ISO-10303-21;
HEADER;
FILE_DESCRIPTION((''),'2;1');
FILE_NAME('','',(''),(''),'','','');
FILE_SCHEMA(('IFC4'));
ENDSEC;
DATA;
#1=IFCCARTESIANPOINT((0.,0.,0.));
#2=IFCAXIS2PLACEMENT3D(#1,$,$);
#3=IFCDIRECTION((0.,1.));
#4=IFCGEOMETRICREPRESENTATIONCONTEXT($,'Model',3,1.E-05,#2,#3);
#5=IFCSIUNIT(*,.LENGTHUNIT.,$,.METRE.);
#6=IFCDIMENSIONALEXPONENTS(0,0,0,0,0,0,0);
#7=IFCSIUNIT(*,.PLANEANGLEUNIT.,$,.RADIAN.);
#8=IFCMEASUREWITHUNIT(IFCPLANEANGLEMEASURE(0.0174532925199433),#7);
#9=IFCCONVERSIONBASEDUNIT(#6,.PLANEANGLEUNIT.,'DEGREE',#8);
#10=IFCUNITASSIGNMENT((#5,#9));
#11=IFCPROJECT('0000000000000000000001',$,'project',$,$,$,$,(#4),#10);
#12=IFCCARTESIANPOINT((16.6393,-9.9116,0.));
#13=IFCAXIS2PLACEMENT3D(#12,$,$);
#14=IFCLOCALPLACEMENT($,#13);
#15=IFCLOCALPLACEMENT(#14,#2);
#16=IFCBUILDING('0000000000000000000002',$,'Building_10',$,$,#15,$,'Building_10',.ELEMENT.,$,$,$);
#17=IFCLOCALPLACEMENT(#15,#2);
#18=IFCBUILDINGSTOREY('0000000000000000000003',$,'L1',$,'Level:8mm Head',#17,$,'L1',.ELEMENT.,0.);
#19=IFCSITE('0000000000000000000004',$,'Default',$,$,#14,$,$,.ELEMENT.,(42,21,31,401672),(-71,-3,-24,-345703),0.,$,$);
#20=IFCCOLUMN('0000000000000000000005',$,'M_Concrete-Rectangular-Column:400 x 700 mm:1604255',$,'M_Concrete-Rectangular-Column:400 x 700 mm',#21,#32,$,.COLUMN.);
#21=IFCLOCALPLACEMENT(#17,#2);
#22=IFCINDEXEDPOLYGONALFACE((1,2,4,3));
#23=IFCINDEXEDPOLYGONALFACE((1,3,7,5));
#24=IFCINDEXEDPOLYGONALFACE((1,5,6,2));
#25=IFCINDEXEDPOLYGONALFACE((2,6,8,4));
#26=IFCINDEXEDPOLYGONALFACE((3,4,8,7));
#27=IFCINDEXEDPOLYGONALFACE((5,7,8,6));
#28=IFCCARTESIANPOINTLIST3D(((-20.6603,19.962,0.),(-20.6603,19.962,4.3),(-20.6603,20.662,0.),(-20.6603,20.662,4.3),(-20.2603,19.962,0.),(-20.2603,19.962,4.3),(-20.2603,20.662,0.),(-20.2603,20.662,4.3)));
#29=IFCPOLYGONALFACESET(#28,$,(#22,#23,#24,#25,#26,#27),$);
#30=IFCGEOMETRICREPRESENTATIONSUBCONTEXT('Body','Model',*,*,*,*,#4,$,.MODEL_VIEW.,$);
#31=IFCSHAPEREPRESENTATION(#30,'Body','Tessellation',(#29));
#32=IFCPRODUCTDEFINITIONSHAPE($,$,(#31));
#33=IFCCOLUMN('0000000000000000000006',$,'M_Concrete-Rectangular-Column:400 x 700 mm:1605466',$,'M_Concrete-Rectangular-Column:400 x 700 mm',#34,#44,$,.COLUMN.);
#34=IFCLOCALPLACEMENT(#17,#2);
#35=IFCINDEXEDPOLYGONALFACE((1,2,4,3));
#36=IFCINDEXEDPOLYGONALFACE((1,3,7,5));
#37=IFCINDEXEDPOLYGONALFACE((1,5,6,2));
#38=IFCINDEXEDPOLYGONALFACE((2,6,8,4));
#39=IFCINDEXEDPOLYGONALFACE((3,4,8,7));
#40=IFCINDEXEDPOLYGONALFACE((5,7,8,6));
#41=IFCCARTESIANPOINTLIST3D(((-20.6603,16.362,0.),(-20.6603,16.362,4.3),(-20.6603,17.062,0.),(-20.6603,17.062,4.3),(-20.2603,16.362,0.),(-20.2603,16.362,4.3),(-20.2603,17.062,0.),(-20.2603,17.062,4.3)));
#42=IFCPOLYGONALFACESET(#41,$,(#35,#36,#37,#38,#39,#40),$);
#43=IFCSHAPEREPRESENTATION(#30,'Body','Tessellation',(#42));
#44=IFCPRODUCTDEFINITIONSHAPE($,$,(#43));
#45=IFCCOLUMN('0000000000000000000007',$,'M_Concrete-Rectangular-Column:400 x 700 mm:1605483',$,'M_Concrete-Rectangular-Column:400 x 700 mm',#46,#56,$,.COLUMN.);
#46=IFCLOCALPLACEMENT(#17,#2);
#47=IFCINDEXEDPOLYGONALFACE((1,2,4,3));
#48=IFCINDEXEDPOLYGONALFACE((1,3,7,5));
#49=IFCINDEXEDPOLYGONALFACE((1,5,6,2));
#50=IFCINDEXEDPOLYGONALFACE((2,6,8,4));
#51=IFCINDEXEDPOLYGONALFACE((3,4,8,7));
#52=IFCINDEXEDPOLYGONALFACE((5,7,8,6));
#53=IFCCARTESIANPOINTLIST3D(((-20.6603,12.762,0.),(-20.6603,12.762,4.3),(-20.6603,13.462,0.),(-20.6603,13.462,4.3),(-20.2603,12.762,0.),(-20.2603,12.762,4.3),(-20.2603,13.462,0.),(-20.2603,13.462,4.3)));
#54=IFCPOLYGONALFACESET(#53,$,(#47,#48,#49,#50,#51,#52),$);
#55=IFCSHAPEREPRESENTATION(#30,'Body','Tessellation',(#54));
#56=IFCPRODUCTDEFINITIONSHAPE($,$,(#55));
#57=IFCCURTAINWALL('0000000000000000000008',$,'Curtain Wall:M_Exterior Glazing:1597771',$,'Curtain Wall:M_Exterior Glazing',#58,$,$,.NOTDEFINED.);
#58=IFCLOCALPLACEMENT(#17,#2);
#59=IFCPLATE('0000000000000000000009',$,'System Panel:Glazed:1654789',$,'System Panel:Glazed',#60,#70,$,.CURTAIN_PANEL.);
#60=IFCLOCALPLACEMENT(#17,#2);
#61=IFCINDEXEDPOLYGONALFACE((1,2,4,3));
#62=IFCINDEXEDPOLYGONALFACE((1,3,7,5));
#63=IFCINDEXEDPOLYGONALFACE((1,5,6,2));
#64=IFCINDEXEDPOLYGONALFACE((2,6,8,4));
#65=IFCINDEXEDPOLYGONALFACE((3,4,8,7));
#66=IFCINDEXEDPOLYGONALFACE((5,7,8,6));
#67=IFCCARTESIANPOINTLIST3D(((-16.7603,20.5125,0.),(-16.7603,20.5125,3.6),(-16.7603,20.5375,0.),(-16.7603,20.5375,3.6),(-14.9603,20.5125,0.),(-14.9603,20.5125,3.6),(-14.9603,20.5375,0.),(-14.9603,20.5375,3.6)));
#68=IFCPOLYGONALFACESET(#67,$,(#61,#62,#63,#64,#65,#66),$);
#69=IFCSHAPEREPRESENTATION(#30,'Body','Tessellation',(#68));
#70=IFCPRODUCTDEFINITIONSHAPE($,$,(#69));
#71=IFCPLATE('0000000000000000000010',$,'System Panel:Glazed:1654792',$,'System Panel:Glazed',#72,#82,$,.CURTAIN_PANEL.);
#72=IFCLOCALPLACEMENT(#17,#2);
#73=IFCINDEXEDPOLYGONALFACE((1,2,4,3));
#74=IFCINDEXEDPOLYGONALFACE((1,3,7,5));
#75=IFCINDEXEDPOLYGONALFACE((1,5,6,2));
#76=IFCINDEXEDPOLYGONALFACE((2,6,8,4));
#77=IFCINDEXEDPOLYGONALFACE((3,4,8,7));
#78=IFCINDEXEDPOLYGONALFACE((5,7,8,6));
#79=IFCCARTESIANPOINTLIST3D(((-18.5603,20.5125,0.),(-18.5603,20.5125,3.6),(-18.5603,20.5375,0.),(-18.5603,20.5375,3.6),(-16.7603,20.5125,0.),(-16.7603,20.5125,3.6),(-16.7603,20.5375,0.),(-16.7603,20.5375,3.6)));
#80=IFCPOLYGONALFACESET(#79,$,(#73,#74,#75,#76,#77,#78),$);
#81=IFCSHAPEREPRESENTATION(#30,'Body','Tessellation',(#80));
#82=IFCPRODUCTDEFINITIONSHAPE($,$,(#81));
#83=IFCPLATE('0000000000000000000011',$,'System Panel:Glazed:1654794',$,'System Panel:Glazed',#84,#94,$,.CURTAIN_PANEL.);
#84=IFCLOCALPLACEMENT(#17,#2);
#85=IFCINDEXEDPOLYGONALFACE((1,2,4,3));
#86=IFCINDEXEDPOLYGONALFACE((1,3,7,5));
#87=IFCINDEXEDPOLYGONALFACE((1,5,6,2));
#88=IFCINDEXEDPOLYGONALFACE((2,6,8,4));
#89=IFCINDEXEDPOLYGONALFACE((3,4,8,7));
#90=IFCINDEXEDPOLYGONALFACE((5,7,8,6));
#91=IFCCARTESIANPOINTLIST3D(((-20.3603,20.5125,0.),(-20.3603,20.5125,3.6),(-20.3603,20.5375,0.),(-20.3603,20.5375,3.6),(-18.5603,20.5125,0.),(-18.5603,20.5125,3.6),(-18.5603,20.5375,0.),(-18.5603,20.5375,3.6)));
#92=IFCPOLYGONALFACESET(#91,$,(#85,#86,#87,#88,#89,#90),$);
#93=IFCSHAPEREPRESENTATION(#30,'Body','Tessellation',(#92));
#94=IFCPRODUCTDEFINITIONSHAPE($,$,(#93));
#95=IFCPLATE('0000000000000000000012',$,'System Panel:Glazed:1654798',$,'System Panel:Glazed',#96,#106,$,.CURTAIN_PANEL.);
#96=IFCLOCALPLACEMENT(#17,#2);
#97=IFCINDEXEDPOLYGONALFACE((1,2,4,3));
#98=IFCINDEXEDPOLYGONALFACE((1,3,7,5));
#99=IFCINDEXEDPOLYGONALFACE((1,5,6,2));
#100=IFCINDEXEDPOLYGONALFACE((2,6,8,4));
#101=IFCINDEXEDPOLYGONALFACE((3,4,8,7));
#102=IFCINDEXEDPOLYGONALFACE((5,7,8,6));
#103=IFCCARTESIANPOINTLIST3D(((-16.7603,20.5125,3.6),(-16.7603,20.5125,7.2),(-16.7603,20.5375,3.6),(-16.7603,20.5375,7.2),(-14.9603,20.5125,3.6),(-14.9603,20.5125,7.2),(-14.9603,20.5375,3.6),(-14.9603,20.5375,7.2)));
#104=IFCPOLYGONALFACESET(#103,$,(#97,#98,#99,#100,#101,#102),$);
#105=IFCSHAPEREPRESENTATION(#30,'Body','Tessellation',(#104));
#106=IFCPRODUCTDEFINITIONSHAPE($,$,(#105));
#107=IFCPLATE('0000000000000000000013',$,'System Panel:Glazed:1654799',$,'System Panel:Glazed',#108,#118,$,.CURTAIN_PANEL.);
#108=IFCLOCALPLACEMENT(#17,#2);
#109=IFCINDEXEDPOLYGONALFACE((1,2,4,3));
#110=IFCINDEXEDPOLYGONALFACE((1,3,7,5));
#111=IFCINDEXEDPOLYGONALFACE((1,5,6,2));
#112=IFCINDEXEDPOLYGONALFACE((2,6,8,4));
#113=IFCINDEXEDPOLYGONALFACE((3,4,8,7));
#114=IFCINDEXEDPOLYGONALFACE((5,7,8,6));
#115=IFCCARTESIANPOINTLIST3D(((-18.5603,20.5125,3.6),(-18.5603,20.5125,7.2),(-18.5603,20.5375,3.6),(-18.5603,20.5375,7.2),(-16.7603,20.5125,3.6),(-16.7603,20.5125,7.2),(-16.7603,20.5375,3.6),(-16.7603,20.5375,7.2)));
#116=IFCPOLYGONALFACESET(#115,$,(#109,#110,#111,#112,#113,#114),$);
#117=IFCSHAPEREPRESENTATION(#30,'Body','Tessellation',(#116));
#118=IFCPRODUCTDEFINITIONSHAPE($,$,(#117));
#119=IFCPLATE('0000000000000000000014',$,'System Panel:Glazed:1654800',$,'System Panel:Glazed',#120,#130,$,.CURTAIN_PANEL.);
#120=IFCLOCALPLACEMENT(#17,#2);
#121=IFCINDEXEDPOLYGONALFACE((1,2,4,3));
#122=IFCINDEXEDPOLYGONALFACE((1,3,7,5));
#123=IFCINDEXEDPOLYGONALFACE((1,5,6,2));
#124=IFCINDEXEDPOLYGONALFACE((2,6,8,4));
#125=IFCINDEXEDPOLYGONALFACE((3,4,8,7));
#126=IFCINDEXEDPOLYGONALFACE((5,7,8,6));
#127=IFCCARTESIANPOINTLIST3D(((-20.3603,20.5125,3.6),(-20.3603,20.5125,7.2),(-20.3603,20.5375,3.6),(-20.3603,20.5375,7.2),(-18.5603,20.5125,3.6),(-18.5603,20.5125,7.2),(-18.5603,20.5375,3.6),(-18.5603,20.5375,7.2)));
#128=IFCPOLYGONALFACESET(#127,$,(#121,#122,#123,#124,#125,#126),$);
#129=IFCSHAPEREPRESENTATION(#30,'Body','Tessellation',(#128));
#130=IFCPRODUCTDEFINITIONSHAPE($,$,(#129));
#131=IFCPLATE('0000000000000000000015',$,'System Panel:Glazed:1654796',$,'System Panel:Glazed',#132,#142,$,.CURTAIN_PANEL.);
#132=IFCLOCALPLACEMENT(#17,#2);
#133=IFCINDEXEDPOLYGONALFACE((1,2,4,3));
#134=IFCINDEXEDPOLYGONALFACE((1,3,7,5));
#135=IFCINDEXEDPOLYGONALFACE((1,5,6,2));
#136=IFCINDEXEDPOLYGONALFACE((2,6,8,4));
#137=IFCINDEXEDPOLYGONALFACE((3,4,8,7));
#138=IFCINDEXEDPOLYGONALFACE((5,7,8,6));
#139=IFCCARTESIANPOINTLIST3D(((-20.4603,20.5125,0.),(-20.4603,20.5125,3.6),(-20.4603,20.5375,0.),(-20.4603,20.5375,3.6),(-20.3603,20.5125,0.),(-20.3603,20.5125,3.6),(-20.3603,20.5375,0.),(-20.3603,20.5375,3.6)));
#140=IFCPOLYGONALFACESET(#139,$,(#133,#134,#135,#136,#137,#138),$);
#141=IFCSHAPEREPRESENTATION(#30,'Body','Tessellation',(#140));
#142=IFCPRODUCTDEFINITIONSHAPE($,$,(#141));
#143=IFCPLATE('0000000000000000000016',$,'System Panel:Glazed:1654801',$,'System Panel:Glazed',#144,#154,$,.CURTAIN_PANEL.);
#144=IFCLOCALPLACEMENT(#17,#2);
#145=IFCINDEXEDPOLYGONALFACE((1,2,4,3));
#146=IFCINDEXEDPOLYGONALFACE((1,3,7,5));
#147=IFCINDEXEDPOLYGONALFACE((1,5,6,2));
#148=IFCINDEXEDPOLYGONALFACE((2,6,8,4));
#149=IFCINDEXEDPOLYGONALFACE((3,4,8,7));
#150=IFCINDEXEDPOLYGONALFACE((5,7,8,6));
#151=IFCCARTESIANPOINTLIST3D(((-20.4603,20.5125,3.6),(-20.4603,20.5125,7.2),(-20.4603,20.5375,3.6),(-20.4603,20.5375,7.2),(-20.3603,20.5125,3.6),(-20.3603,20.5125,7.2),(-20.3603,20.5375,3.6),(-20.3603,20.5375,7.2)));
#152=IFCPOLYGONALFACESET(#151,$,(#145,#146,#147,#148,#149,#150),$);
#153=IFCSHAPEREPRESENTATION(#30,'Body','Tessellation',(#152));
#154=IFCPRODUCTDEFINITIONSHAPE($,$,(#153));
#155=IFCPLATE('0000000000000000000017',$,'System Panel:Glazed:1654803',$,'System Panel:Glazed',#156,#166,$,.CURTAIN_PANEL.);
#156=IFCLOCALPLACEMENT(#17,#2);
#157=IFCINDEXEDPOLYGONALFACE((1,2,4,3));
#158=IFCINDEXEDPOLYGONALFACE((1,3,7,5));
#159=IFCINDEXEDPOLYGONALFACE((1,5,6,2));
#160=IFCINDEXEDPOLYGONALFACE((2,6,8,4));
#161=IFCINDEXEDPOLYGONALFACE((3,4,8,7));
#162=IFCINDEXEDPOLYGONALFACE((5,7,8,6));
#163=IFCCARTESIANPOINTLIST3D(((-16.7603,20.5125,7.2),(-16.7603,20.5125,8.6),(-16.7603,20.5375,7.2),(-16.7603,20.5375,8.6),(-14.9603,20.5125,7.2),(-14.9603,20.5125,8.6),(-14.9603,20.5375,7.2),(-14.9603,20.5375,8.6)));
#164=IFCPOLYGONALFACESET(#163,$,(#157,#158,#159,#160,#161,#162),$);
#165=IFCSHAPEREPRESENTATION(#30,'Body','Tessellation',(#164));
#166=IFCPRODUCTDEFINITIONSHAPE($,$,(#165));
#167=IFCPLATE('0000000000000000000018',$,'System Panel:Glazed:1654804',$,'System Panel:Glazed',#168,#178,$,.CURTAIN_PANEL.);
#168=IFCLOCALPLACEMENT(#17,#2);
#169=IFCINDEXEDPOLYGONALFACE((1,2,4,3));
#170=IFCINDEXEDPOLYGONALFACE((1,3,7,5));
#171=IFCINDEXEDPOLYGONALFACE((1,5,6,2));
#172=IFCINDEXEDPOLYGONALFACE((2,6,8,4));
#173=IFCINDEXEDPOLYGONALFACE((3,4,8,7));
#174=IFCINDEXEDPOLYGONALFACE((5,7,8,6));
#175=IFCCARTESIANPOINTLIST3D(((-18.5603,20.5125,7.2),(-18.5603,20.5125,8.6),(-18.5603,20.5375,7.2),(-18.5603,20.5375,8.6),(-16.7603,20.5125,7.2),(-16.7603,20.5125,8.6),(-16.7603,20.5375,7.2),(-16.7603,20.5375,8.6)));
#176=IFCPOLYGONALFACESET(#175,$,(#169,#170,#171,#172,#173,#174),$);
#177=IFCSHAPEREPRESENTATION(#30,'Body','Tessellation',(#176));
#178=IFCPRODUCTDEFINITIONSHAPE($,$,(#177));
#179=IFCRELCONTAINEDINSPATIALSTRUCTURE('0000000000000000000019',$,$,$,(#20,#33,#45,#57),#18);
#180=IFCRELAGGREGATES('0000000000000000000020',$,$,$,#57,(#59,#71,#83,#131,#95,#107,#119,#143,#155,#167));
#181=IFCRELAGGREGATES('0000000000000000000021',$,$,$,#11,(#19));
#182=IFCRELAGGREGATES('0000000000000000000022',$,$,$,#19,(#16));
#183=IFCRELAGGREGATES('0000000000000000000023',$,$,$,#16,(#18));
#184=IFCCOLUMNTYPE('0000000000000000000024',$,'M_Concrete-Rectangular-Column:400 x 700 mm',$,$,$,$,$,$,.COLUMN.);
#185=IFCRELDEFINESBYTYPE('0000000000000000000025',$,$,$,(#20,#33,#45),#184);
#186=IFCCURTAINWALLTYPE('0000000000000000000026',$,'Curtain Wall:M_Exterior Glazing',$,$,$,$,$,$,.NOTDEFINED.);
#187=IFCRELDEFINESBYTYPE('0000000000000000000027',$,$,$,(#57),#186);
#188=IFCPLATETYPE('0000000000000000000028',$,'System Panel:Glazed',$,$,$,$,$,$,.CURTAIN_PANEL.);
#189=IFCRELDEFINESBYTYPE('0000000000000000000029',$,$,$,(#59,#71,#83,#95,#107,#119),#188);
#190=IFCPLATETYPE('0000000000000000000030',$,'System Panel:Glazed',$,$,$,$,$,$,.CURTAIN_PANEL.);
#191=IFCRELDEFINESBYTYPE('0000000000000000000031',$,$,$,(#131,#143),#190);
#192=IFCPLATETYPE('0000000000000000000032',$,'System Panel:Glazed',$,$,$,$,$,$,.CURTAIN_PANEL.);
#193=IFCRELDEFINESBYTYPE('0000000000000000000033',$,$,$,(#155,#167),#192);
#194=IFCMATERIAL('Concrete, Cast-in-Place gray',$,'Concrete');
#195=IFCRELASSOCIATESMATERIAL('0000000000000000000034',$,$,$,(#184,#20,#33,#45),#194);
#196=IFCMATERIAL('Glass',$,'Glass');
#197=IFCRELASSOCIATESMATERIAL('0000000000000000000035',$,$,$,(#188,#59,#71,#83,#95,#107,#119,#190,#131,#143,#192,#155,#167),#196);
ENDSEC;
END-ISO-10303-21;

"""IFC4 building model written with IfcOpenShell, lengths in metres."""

from ifc_helpers import new_model, entity, si_unit, converted_unit, direction, frame, origin, place, context, subcontext, project, spatial, indexed_curve, outline, extrude, source, transform, mapped, material, type_object, type_shapes, element, aggregate, save


model = new_model("IFC4")

# Units and contexts
model_context = context("Model", 3, precision=1e-05, world=origin(), true_north=direction((0.0, 1.0)))
body_context = subcontext(model_context, "Body", "Model", "MODEL_VIEW")
ifc_project = project(units=[si_unit("LENGTHUNIT", "METRE"), converted_unit("PLANEANGLEUNIT", "DEGREE", entity("IfcPlaneAngleMeasure", 0.0174532925199433), si_unit("PLANEANGLEUNIT", "RADIAN"), dimensions=[0, 0, 0, 0, 0, 0, 0])], contexts=[model_context])

# Site, building, storey
site_placement = place(None, frame((16.6393, -9.9116, 0.0)))
site = spatial("IfcSite", under=ifc_project, at=site_placement, Name="Default", CompositionType="ELEMENT", RefLatitude=(42, 21, 31, 401672), RefLongitude=(-71, -3, -24, -345703), RefElevation=0.0)
building_placement = place(site_placement, origin())
building = spatial("IfcBuilding", under=site, at=building_placement, Name="Building_10", LongName="Building_10", CompositionType="ELEMENT")
storey_placement = place(building_placement, origin())
storey = spatial("IfcBuildingStorey", under=building, at=storey_placement, Name="L1", ObjectType="Level:8mm Head", LongName="L1", CompositionType="ELEMENT", Elevation=0.0)

# Columns
ifc_material_1 = material(Name="Concrete, Cast-in-Place gray", Category="Concrete")
column_type = type_object("IfcColumnType", Name="M_Concrete-Rectangular-Column:400 x 700 mm", PredefinedType="COLUMN", material=ifc_material_1)
shared_shape_1 = source(origin(), body_context, "Body", "SweptSolid", [
    extrude(outline(indexed_curve([(-0.2, -0.35), (0.2, -0.35), (0.2, 0.35), (-0.2, 0.35), (-0.2, -0.35)], self_intersect=False)), frame((0.0, 0.0, 0.0), z_axis=(0.0, 0.0, 1.0), x_axis=(-1.0, 0.0, 0.0)), (0.0, 0.0, 1.0), 4.3),
])
type_shapes(column_type, [shared_shape_1])
for number, where, name in (
    (1, (-20.4603, 20.312, 0.0), "M_Concrete-Rectangular-Column:400 x 700 mm:1604255"),
    (2, (-20.4603, 16.712, 0.0), "M_Concrete-Rectangular-Column:400 x 700 mm:1605466"),
    (3, (-20.4603, 13.112, 0.0), "M_Concrete-Rectangular-Column:400 x 700 mm:1605483"),
):
    element("IfcColumn", number, at=place(storey_placement, frame(where)), inside=storey, type_object=column_type, material=ifc_material_1, Name=name, ObjectType="M_Concrete-Rectangular-Column:400 x 700 mm", PredefinedType="COLUMN", context=body_context, shape_type="MappedRepresentation", body=[
        mapped(shared_shape_1, transform((0.0, 0.0, 0.0), scale=1.0)),
    ])

# Curtain wall, plates
curtain_wall_type = type_object("IfcCurtainWallType", Name="Curtain Wall:M_Exterior Glazing", PredefinedType="NOTDEFINED")
curtain_wall_placement = place(storey_placement, origin())
curtain_wall = element("IfcCurtainWall", 4, at=curtain_wall_placement, inside=storey, type_object=curtain_wall_type, Name="Curtain Wall:M_Exterior Glazing:1597771", ObjectType="Curtain Wall:M_Exterior Glazing", PredefinedType="NOTDEFINED")
ifc_material_2 = material(Name="Glass", Category="Glass")
plate_type_1 = type_object("IfcPlateType", Name="System Panel:Glazed", PredefinedType="CURTAIN_PANEL", material=ifc_material_2)
shared_shape_2 = source(origin(), body_context, "Body", "SweptSolid", [
    extrude(outline(indexed_curve([(-0.0125, -0.9), (0.0125, -0.9), (0.0125, 0.9), (-0.0125, 0.9), (-0.0125, -0.9)], self_intersect=False)), frame((0.0, 0.037, 0.0), z_axis=(0.0, 0.0, 1.0), x_axis=(0.0, 1.0, 0.0)), (0.0, 0.0, 1.0), 3.6),
])
type_shapes(plate_type_1, [shared_shape_2])
plate_1_placement = place(curtain_wall_placement, frame((-15.8603, 20.562, 0.0), z_axis=(0.0, 0.0, 1.0), x_axis=(-1.0, 0.0, 0.0)))
plate_1 = element("IfcPlate", 5, at=plate_1_placement, type_object=plate_type_1, material=ifc_material_2, Name="System Panel:Glazed:1654789", ObjectType="System Panel:Glazed", PredefinedType="CURTAIN_PANEL", context=body_context, shape_type="MappedRepresentation", body=[
    mapped(shared_shape_2, transform((0.0, 0.0, 0.0), scale=1.0)),
])
plate_2_placement = place(curtain_wall_placement, frame((-17.6603, 20.562, 0.0), z_axis=(0.0, 0.0, 1.0), x_axis=(-1.0, 0.0, 0.0)))
plate_2 = element("IfcPlate", 6, at=plate_2_placement, type_object=plate_type_1, material=ifc_material_2, Name="System Panel:Glazed:1654792", ObjectType="System Panel:Glazed", PredefinedType="CURTAIN_PANEL", context=body_context, shape_type="MappedRepresentation", body=[
    mapped(shared_shape_2, transform((0.0, 0.0, 0.0), scale=1.0)),
])
plate_3_placement = place(curtain_wall_placement, frame((-19.4603, 20.562, 0.0), z_axis=(0.0, 0.0, 1.0), x_axis=(-1.0, 0.0, 0.0)))
plate_3 = element("IfcPlate", 7, at=plate_3_placement, type_object=plate_type_1, material=ifc_material_2, Name="System Panel:Glazed:1654794", ObjectType="System Panel:Glazed", PredefinedType="CURTAIN_PANEL", context=body_context, shape_type="MappedRepresentation", body=[
    mapped(shared_shape_2, transform((0.0, 0.0, 0.0), scale=1.0)),
])
plate_4_placement = place(curtain_wall_placement, frame((-15.8603, 20.562, 3.6), z_axis=(0.0, 0.0, 1.0), x_axis=(-1.0, 0.0, 0.0)))
plate_4 = element("IfcPlate", 8, at=plate_4_placement, type_object=plate_type_1, material=ifc_material_2, Name="System Panel:Glazed:1654798", ObjectType="System Panel:Glazed", PredefinedType="CURTAIN_PANEL", context=body_context, shape_type="MappedRepresentation", body=[
    mapped(shared_shape_2, transform((0.0, 0.0, 0.0), scale=1.0)),
])
plate_5_placement = place(curtain_wall_placement, frame((-17.6603, 20.562, 3.6), z_axis=(0.0, 0.0, 1.0), x_axis=(-1.0, 0.0, 0.0)))
plate_5 = element("IfcPlate", 9, at=plate_5_placement, type_object=plate_type_1, material=ifc_material_2, Name="System Panel:Glazed:1654799", ObjectType="System Panel:Glazed", PredefinedType="CURTAIN_PANEL", context=body_context, shape_type="MappedRepresentation", body=[
    mapped(shared_shape_2, transform((0.0, 0.0, 0.0), scale=1.0)),
])
plate_6_placement = place(curtain_wall_placement, frame((-19.4603, 20.562, 3.6), z_axis=(0.0, 0.0, 1.0), x_axis=(-1.0, 0.0, 0.0)))
plate_6 = element("IfcPlate", 10, at=plate_6_placement, type_object=plate_type_1, material=ifc_material_2, Name="System Panel:Glazed:1654800", ObjectType="System Panel:Glazed", PredefinedType="CURTAIN_PANEL", context=body_context, shape_type="MappedRepresentation", body=[
    mapped(shared_shape_2, transform((0.0, 0.0, 0.0), scale=1.0)),
])
plate_type_2 = type_object("IfcPlateType", Name="System Panel:Glazed", PredefinedType="CURTAIN_PANEL", material=ifc_material_2)
shared_shape_3 = source(origin(), body_context, "Body", "SweptSolid", [
    extrude(outline(indexed_curve([(-0.0125, -0.05), (0.0125, -0.05), (0.0125, 0.05), (-0.0125, 0.05), (-0.0125, -0.05)], self_intersect=False)), frame((0.0, 0.037, 0.0), z_axis=(0.0, 0.0, 1.0), x_axis=(0.0, 1.0, 0.0)), (0.0, 0.0, 1.0), 3.6),
])
type_shapes(plate_type_2, [shared_shape_3])
plate_7_placement = place(curtain_wall_placement, frame((-20.4103, 20.562, 0.0), z_axis=(0.0, 0.0, 1.0), x_axis=(-1.0, 0.0, 0.0)))
plate_7 = element("IfcPlate", 11, at=plate_7_placement, type_object=plate_type_2, material=ifc_material_2, Name="System Panel:Glazed:1654796", ObjectType="System Panel:Glazed", PredefinedType="CURTAIN_PANEL", context=body_context, shape_type="MappedRepresentation", body=[
    mapped(shared_shape_3, transform((0.0, 0.0, 0.0), scale=1.0)),
])
plate_8_placement = place(curtain_wall_placement, frame((-20.4103, 20.562, 3.6), z_axis=(0.0, 0.0, 1.0), x_axis=(-1.0, 0.0, 0.0)))
plate_8 = element("IfcPlate", 12, at=plate_8_placement, type_object=plate_type_2, material=ifc_material_2, Name="System Panel:Glazed:1654801", ObjectType="System Panel:Glazed", PredefinedType="CURTAIN_PANEL", context=body_context, shape_type="MappedRepresentation", body=[
    mapped(shared_shape_3, transform((0.0, 0.0, 0.0), scale=1.0)),
])
plate_type_3 = type_object("IfcPlateType", Name="System Panel:Glazed", PredefinedType="CURTAIN_PANEL", material=ifc_material_2)
shared_shape_4 = source(origin(), body_context, "Body", "SweptSolid", [
    extrude(outline(indexed_curve([(-0.0125, -0.9), (0.0125, -0.9), (0.0125, 0.9), (-0.0125, 0.9), (-0.0125, -0.9)], self_intersect=False)), frame((0.0, 0.037, 0.0), z_axis=(0.0, 0.0, 1.0), x_axis=(0.0, 1.0, 0.0)), (0.0, 0.0, 1.0), 1.4),
])
type_shapes(plate_type_3, [shared_shape_4])
plate_9_placement = place(curtain_wall_placement, frame((-15.8603, 20.562, 7.2), z_axis=(0.0, 0.0, 1.0), x_axis=(-1.0, 0.0, 0.0)))
plate_9 = element("IfcPlate", 13, at=plate_9_placement, type_object=plate_type_3, material=ifc_material_2, Name="System Panel:Glazed:1654803", ObjectType="System Panel:Glazed", PredefinedType="CURTAIN_PANEL", context=body_context, shape_type="MappedRepresentation", body=[
    mapped(shared_shape_4, transform((0.0, 0.0, 0.0), scale=1.0)),
])
plate_10_placement = place(curtain_wall_placement, frame((-17.6603, 20.562, 7.2), z_axis=(0.0, 0.0, 1.0), x_axis=(-1.0, 0.0, 0.0)))
plate_10 = element("IfcPlate", 14, at=plate_10_placement, type_object=plate_type_3, material=ifc_material_2, Name="System Panel:Glazed:1654804", ObjectType="System Panel:Glazed", PredefinedType="CURTAIN_PANEL", context=body_context, shape_type="MappedRepresentation", body=[
    mapped(shared_shape_4, transform((0.0, 0.0, 0.0), scale=1.0)),
])
aggregate(curtain_wall, [plate_1, plate_2, plate_3, plate_7, plate_4, plate_5, plate_6, plate_8, plate_9, plate_10])

save(model, "model.ifc")
